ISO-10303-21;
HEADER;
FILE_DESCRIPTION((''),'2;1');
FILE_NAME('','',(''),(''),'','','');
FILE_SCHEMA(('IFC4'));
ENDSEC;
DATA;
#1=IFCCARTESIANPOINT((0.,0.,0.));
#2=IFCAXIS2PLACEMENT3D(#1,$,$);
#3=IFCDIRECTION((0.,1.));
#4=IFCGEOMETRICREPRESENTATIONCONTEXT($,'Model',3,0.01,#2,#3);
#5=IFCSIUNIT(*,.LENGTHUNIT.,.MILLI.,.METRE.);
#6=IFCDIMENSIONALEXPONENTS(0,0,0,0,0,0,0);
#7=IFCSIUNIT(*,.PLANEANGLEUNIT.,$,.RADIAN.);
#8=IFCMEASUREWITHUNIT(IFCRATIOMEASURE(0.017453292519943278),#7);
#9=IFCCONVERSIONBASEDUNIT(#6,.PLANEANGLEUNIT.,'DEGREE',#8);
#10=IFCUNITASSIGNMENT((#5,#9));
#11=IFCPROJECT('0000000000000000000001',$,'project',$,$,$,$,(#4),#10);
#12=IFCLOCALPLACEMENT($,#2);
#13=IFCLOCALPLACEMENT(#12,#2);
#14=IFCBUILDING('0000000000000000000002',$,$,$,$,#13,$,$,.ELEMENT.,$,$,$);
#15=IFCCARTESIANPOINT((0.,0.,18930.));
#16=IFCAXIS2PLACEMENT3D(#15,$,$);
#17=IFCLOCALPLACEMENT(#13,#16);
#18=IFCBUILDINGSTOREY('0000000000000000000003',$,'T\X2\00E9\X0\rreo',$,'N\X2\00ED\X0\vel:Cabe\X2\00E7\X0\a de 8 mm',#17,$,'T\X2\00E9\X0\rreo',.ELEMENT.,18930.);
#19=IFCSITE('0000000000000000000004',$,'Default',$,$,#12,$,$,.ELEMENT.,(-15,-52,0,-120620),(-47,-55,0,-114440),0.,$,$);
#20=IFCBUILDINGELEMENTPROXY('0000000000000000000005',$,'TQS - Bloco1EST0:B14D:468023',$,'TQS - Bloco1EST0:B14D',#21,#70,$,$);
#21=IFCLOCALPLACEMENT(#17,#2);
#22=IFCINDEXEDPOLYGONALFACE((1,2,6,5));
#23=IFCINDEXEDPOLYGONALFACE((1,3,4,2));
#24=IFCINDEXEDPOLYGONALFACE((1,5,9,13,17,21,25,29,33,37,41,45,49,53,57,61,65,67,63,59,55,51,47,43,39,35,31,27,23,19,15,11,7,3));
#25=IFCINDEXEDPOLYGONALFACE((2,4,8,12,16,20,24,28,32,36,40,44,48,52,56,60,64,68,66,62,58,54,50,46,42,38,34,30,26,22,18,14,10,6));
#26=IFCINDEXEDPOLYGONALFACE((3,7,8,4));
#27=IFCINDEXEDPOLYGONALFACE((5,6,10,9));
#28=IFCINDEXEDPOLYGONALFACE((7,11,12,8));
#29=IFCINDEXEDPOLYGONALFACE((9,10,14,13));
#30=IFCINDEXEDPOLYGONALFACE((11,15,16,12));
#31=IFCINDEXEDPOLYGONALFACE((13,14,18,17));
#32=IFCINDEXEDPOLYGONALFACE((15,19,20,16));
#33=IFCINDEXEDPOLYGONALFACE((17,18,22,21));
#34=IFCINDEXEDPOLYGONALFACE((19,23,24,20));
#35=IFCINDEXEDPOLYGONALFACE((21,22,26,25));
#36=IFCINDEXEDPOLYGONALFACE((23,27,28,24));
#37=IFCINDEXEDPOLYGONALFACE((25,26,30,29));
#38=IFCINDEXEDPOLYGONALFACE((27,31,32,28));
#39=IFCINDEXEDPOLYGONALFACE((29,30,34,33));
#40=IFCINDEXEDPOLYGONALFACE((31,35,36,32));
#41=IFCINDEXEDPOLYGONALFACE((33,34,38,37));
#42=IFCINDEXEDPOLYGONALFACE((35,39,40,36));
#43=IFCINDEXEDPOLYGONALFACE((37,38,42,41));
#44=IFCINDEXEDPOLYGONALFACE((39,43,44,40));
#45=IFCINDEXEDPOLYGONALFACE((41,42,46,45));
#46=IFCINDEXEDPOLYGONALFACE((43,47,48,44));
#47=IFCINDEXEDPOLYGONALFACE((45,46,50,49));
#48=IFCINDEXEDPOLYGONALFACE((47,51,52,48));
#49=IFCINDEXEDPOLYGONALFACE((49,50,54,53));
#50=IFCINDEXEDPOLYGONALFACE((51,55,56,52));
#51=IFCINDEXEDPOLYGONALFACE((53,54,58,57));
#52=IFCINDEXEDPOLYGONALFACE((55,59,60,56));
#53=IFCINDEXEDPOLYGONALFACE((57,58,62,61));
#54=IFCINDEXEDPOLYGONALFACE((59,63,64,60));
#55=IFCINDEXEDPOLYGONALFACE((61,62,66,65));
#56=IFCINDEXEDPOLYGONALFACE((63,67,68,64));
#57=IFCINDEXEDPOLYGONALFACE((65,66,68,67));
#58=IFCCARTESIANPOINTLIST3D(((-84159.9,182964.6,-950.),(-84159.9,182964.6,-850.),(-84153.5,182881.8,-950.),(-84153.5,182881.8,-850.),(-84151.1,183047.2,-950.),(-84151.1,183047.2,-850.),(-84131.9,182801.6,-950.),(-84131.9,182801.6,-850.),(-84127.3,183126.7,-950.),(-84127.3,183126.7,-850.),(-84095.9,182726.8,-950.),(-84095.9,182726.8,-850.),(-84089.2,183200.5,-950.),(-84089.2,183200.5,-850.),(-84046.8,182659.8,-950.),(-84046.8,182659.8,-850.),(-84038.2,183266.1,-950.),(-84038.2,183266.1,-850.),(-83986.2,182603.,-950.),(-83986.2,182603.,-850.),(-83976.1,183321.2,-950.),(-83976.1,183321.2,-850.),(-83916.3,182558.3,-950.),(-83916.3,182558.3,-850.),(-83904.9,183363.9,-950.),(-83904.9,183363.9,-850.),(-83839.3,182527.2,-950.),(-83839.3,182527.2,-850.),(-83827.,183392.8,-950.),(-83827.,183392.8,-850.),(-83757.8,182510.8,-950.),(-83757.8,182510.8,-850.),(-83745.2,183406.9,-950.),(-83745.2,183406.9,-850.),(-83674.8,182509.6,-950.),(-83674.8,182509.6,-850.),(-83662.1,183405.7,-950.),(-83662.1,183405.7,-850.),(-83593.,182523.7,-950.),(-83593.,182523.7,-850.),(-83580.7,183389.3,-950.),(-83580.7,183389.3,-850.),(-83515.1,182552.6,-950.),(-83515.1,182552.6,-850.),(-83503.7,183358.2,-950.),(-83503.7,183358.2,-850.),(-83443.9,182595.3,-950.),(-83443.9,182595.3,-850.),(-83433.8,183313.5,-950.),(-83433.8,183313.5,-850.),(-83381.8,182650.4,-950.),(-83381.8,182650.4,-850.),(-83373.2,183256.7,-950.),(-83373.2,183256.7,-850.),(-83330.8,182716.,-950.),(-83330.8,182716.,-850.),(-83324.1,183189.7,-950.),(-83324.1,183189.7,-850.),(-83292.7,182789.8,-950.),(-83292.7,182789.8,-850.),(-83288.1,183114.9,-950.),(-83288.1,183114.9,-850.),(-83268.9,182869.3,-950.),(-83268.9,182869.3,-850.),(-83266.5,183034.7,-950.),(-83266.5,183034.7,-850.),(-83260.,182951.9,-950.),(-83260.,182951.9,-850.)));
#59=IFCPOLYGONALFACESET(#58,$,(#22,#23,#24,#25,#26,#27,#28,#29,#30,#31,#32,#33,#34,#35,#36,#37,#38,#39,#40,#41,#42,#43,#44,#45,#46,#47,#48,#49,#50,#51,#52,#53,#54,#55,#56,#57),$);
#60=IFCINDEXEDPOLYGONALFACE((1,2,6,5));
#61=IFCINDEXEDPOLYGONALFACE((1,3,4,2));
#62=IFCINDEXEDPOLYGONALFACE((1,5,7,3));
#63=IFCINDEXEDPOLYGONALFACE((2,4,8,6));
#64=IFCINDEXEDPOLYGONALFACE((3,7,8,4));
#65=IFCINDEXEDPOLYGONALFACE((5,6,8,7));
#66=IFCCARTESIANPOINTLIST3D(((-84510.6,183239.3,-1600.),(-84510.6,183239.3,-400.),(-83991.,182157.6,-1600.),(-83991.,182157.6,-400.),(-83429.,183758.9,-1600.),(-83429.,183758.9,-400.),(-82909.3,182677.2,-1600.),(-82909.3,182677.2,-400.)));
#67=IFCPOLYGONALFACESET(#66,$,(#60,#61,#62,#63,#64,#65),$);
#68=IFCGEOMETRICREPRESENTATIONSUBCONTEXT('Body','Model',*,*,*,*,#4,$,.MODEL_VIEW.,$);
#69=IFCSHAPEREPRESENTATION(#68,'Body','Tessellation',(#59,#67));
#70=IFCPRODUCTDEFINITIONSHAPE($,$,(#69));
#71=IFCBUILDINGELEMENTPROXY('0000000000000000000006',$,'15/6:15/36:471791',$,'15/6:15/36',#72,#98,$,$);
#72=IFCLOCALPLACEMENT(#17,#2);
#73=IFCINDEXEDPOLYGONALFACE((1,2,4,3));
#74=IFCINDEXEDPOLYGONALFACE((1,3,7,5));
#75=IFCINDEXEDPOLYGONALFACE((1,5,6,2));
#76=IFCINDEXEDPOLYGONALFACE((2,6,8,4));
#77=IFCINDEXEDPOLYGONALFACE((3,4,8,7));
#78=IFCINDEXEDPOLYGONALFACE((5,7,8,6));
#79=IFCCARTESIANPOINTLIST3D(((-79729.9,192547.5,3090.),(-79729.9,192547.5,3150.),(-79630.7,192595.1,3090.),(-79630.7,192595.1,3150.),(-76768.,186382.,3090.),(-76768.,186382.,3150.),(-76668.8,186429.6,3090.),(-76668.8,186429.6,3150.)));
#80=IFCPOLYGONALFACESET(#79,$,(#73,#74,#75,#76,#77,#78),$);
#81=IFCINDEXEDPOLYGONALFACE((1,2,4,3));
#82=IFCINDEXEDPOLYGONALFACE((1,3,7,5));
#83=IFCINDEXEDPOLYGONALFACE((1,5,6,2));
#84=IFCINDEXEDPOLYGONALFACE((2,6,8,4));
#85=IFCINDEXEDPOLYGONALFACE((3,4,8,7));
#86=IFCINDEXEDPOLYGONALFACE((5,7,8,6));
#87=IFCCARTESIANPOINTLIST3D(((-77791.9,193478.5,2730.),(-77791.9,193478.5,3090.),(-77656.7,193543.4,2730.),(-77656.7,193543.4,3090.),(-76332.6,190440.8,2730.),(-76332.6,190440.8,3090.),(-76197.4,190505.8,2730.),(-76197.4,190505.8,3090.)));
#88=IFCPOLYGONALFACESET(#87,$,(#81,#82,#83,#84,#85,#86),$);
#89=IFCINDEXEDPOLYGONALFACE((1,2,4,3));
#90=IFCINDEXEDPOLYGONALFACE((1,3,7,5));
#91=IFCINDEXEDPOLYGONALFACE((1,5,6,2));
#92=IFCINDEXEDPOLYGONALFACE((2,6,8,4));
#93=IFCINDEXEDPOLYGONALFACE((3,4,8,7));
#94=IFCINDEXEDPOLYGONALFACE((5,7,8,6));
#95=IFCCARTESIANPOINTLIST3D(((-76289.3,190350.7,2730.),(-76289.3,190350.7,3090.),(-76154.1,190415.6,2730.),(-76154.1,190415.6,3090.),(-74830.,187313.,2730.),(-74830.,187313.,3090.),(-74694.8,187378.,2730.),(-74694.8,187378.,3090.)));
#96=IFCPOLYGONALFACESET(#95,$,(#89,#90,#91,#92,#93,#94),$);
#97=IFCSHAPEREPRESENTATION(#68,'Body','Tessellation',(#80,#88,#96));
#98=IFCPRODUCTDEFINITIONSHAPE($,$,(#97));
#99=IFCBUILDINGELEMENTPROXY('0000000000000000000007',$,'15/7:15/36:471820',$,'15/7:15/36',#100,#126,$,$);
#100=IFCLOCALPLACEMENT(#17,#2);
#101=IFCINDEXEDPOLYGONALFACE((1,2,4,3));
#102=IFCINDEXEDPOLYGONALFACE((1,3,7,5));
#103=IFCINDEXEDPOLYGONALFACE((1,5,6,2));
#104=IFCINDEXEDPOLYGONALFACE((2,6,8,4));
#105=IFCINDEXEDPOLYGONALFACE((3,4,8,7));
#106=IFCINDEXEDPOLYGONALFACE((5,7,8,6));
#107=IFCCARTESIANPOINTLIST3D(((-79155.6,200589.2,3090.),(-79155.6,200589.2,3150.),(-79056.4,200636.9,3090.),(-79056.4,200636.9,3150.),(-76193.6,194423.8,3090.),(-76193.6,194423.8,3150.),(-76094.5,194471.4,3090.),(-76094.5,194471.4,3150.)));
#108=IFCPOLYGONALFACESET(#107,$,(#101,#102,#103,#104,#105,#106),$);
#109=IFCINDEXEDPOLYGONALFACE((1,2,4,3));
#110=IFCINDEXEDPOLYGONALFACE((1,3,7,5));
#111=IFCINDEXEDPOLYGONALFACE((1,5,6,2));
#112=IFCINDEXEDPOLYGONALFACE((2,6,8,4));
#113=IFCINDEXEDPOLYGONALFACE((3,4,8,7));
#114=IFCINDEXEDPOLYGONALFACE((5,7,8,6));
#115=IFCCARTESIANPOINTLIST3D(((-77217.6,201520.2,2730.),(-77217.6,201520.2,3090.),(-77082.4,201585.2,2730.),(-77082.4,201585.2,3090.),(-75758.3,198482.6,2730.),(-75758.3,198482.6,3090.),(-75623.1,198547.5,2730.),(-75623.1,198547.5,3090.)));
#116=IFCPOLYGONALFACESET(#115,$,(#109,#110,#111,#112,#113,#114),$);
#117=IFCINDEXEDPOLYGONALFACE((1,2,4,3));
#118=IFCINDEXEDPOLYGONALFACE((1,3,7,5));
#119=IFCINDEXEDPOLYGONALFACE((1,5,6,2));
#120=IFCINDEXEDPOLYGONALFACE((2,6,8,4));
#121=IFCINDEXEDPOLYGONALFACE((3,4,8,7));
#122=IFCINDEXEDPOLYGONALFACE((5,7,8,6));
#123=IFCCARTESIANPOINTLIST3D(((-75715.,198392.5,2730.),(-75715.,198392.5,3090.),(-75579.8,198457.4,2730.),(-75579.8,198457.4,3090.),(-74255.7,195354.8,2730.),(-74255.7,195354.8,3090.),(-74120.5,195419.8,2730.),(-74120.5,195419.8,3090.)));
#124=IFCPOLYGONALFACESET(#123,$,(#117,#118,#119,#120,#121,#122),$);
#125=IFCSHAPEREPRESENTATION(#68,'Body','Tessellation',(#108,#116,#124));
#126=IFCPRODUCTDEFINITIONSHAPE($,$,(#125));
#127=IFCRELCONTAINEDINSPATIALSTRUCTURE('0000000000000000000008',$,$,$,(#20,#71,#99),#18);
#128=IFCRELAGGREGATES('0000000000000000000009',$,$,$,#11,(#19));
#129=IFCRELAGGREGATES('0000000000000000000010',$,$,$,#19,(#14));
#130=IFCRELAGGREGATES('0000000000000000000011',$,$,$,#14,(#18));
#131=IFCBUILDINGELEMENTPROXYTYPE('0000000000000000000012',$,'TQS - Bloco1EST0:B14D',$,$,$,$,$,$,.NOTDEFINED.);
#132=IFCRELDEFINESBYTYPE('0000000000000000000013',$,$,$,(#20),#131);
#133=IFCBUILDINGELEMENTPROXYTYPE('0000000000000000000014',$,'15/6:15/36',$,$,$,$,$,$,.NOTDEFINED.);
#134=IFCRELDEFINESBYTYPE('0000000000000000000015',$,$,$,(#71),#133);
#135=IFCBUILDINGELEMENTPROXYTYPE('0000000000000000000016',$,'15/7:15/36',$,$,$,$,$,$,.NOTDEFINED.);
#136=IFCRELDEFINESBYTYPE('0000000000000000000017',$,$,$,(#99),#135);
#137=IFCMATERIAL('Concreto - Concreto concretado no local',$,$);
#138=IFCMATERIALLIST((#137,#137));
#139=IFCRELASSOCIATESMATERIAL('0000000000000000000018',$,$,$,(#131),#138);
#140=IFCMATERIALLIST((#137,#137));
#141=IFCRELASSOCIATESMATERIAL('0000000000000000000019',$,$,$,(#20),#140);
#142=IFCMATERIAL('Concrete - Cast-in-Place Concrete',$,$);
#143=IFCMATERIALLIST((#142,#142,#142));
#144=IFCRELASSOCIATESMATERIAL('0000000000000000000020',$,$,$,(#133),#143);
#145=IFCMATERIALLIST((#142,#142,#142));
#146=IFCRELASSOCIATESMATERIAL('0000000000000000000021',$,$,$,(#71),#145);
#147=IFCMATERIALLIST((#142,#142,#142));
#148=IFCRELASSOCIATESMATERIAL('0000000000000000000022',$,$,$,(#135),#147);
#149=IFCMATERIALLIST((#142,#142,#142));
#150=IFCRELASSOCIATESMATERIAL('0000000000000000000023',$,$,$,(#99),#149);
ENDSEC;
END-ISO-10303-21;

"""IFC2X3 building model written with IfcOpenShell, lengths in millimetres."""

from ifc_helpers import new_model, entity, si_unit, converted_unit, direction, frame, frame_2d, origin, origin_2d_with_axis, place, context, subcontext, project, spatial, rectangle, circle, extrude, source, transform, mapped, material, material_list, type_object, type_shapes, element, save


model = new_model("IFC2X3")

# Units and contexts
model_context = context("Model", 3, precision=0.01, world=origin(), true_north=direction((0.0, 1.0)))
body_context = subcontext(model_context, "Body", "Model", "MODEL_VIEW")
ifc_project = project(units=[si_unit("LENGTHUNIT", "METRE", prefix="MILLI"), converted_unit("PLANEANGLEUNIT", "DEGREE", entity("IfcRatioMeasure", 0.017453292519943278), si_unit("PLANEANGLEUNIT", "RADIAN"), dimensions=[0, 0, 0, 0, 0, 0, 0])], contexts=[model_context])

# Site, building, storey
site_placement = place(None, origin())
site = spatial("IfcSite", under=ifc_project, at=site_placement, Name="Default", CompositionType="ELEMENT", RefLatitude=(-15, -52, 0, -120620), RefLongitude=(-47, -55, 0, -114440), RefElevation=0.0)
building_placement = place(site_placement, origin())
building = spatial("IfcBuilding", under=site, at=building_placement, CompositionType="ELEMENT")
storey_placement = place(building_placement, frame((0.0, 0.0, 18930.0)))
storey = spatial("IfcBuildingStorey", under=building, at=storey_placement, Name="Térreo", ObjectType="Nível:Cabeça de 8 mm", LongName="Térreo", CompositionType="ELEMENT", Elevation=18930.0)

# Building element proxies
ifc_material_1 = material(Name="Concreto - Concreto concretado no local")
ifc_material_list_1 = material_list([ifc_material_1, ifc_material_1])
ifc_material_list_2 = material_list([ifc_material_1, ifc_material_1])
building_element_proxy_type_1 = type_object("IfcBuildingElementProxyType", Name="TQS - Bloco1EST0:B14D", PredefinedType="NOTDEFINED", material=ifc_material_list_2)
shared_shape_1 = source(origin(), body_context, "Body", "SweptSolid", [
    extrude(circle(Radius=450.0, at=frame_2d((0.0, 0.0), x_axis=(1.0, 0.0))), frame((0.0, 0.0, -550.0)), (0.0, 0.0, 1.0), 100.0),
    extrude(rectangle(XDim=1200.0, YDim=1200.0, at=origin_2d_with_axis()), frame((0.0, 0.0, -1200.0), z_axis=(0.0, 0.0, 1.0), x_axis=(-1.0, 0.0, 0.0)), (0.0, 0.0, 1.0), 1200.0),
])
type_shapes(building_element_proxy_type_1, [shared_shape_1])
proxy_1_placement = place(storey_placement, frame((-83710.0, 182958.3, -400.0), z_axis=(0.0, 0.0, 1.0), x_axis=(-0.43303, 0.90138, 0.0)))
element("IfcBuildingElementProxy", 1, at=proxy_1_placement, inside=storey, type_object=building_element_proxy_type_1, material=ifc_material_list_1, Name="TQS - Bloco1EST0:B14D:468023", ObjectType="TQS - Bloco1EST0:B14D", context=body_context, shape_type="MappedRepresentation", body=[
    mapped(shared_shape_1, transform((0.0, 0.0, 0.0), scale=1.0)),
])
ifc_material_2 = material(Name="Concrete - Cast-in-Place Concrete")
ifc_material_list_3 = material_list([ifc_material_2, ifc_material_2, ifc_material_2])
ifc_material_list_4 = material_list([ifc_material_2, ifc_material_2, ifc_material_2])
building_element_proxy_type_2 = type_object("IfcBuildingElementProxyType", Name="15/6:15/36", PredefinedType="NOTDEFINED", material=ifc_material_list_4)
shared_shape_2 = source(origin(), body_context, "Body", "SweptSolid", [
    extrude(rectangle(XDim=110.0, YDim=6840.0, at=frame_2d((0.0, 0.0), x_axis=(1.0, 0.0))), frame((1530.5, 3106.5, 360.0), z_axis=(0.0, 0.0, 1.0), x_axis=(0.90138, 0.43303, 0.0)), (0.0, 0.0, 1.0), 60.0),
    extrude(rectangle(XDim=3370.0, YDim=150.0, at=frame_2d((0.0, 0.0), x_axis=(1.0, 0.0))), frame((2735.2, 5610.1, 0.0), z_axis=(0.0, 0.0, 1.0), x_axis=(0.43303, -0.90138, 0.0)), (0.0, 0.0, 1.0), 360.0),
    extrude(rectangle(XDim=3370.0, YDim=150.0, at=frame_2d((0.0, 0.0), x_axis=(1.0, 0.0))), frame((4237.8, 2482.3, 0.0), z_axis=(0.0, 0.0, 1.0), x_axis=(0.43303, -0.90138, 0.0)), (0.0, 0.0, 1.0), 360.0),
])
type_shapes(building_element_proxy_type_2, [shared_shape_2])
proxy_2_placement = place(storey_placement, frame((-79729.9, 186382.0, 2730.0)))
element("IfcBuildingElementProxy", 2, at=proxy_2_placement, inside=storey, type_object=building_element_proxy_type_2, material=ifc_material_list_3, Name="15/6:15/36:471791", ObjectType="15/6:15/36", context=body_context, shape_type="MappedRepresentation", body=[
    mapped(shared_shape_2, transform((0.0, 0.0, 0.0), scale=1.0)),
])
ifc_material_list_5 = material_list([ifc_material_2, ifc_material_2, ifc_material_2])
ifc_material_list_6 = material_list([ifc_material_2, ifc_material_2, ifc_material_2])
building_element_proxy_type_3 = type_object("IfcBuildingElementProxyType", Name="15/7:15/36", PredefinedType="NOTDEFINED", material=ifc_material_list_6)
shared_shape_3 = source(origin(), body_context, "Body", "SweptSolid", [
    extrude(rectangle(XDim=110.0, YDim=6840.0, at=frame_2d((0.0, 0.0), x_axis=(1.0, 0.0))), frame((1530.5, 3106.5, 360.0), z_axis=(0.0, 0.0, 1.0), x_axis=(0.90138, 0.43303, 0.0)), (0.0, 0.0, 1.0), 60.0),
    extrude(rectangle(XDim=3370.0, YDim=150.0, at=frame_2d((0.0, 0.0), x_axis=(1.0, 0.0))), frame((2735.2, 5610.1, 0.0), z_axis=(0.0, 0.0, 1.0), x_axis=(0.43303, -0.90138, 0.0)), (0.0, 0.0, 1.0), 360.0),
    extrude(rectangle(XDim=3370.0, YDim=150.0, at=frame_2d((0.0, 0.0), x_axis=(1.0, 0.0))), frame((4237.8, 2482.3, 0.0), z_axis=(0.0, 0.0, 1.0), x_axis=(0.43303, -0.90138, 0.0)), (0.0, 0.0, 1.0), 360.0),
])
type_shapes(building_element_proxy_type_3, [shared_shape_3])
proxy_3_placement = place(storey_placement, frame((-79155.6, 194423.8, 2730.0)))
element("IfcBuildingElementProxy", 3, at=proxy_3_placement, inside=storey, type_object=building_element_proxy_type_3, material=ifc_material_list_5, Name="15/7:15/36:471820", ObjectType="15/7:15/36", context=body_context, shape_type="MappedRepresentation", body=[
    mapped(shared_shape_3, transform((0.0, 0.0, 0.0), scale=1.0)),
])

save(model, "model.ifc")
